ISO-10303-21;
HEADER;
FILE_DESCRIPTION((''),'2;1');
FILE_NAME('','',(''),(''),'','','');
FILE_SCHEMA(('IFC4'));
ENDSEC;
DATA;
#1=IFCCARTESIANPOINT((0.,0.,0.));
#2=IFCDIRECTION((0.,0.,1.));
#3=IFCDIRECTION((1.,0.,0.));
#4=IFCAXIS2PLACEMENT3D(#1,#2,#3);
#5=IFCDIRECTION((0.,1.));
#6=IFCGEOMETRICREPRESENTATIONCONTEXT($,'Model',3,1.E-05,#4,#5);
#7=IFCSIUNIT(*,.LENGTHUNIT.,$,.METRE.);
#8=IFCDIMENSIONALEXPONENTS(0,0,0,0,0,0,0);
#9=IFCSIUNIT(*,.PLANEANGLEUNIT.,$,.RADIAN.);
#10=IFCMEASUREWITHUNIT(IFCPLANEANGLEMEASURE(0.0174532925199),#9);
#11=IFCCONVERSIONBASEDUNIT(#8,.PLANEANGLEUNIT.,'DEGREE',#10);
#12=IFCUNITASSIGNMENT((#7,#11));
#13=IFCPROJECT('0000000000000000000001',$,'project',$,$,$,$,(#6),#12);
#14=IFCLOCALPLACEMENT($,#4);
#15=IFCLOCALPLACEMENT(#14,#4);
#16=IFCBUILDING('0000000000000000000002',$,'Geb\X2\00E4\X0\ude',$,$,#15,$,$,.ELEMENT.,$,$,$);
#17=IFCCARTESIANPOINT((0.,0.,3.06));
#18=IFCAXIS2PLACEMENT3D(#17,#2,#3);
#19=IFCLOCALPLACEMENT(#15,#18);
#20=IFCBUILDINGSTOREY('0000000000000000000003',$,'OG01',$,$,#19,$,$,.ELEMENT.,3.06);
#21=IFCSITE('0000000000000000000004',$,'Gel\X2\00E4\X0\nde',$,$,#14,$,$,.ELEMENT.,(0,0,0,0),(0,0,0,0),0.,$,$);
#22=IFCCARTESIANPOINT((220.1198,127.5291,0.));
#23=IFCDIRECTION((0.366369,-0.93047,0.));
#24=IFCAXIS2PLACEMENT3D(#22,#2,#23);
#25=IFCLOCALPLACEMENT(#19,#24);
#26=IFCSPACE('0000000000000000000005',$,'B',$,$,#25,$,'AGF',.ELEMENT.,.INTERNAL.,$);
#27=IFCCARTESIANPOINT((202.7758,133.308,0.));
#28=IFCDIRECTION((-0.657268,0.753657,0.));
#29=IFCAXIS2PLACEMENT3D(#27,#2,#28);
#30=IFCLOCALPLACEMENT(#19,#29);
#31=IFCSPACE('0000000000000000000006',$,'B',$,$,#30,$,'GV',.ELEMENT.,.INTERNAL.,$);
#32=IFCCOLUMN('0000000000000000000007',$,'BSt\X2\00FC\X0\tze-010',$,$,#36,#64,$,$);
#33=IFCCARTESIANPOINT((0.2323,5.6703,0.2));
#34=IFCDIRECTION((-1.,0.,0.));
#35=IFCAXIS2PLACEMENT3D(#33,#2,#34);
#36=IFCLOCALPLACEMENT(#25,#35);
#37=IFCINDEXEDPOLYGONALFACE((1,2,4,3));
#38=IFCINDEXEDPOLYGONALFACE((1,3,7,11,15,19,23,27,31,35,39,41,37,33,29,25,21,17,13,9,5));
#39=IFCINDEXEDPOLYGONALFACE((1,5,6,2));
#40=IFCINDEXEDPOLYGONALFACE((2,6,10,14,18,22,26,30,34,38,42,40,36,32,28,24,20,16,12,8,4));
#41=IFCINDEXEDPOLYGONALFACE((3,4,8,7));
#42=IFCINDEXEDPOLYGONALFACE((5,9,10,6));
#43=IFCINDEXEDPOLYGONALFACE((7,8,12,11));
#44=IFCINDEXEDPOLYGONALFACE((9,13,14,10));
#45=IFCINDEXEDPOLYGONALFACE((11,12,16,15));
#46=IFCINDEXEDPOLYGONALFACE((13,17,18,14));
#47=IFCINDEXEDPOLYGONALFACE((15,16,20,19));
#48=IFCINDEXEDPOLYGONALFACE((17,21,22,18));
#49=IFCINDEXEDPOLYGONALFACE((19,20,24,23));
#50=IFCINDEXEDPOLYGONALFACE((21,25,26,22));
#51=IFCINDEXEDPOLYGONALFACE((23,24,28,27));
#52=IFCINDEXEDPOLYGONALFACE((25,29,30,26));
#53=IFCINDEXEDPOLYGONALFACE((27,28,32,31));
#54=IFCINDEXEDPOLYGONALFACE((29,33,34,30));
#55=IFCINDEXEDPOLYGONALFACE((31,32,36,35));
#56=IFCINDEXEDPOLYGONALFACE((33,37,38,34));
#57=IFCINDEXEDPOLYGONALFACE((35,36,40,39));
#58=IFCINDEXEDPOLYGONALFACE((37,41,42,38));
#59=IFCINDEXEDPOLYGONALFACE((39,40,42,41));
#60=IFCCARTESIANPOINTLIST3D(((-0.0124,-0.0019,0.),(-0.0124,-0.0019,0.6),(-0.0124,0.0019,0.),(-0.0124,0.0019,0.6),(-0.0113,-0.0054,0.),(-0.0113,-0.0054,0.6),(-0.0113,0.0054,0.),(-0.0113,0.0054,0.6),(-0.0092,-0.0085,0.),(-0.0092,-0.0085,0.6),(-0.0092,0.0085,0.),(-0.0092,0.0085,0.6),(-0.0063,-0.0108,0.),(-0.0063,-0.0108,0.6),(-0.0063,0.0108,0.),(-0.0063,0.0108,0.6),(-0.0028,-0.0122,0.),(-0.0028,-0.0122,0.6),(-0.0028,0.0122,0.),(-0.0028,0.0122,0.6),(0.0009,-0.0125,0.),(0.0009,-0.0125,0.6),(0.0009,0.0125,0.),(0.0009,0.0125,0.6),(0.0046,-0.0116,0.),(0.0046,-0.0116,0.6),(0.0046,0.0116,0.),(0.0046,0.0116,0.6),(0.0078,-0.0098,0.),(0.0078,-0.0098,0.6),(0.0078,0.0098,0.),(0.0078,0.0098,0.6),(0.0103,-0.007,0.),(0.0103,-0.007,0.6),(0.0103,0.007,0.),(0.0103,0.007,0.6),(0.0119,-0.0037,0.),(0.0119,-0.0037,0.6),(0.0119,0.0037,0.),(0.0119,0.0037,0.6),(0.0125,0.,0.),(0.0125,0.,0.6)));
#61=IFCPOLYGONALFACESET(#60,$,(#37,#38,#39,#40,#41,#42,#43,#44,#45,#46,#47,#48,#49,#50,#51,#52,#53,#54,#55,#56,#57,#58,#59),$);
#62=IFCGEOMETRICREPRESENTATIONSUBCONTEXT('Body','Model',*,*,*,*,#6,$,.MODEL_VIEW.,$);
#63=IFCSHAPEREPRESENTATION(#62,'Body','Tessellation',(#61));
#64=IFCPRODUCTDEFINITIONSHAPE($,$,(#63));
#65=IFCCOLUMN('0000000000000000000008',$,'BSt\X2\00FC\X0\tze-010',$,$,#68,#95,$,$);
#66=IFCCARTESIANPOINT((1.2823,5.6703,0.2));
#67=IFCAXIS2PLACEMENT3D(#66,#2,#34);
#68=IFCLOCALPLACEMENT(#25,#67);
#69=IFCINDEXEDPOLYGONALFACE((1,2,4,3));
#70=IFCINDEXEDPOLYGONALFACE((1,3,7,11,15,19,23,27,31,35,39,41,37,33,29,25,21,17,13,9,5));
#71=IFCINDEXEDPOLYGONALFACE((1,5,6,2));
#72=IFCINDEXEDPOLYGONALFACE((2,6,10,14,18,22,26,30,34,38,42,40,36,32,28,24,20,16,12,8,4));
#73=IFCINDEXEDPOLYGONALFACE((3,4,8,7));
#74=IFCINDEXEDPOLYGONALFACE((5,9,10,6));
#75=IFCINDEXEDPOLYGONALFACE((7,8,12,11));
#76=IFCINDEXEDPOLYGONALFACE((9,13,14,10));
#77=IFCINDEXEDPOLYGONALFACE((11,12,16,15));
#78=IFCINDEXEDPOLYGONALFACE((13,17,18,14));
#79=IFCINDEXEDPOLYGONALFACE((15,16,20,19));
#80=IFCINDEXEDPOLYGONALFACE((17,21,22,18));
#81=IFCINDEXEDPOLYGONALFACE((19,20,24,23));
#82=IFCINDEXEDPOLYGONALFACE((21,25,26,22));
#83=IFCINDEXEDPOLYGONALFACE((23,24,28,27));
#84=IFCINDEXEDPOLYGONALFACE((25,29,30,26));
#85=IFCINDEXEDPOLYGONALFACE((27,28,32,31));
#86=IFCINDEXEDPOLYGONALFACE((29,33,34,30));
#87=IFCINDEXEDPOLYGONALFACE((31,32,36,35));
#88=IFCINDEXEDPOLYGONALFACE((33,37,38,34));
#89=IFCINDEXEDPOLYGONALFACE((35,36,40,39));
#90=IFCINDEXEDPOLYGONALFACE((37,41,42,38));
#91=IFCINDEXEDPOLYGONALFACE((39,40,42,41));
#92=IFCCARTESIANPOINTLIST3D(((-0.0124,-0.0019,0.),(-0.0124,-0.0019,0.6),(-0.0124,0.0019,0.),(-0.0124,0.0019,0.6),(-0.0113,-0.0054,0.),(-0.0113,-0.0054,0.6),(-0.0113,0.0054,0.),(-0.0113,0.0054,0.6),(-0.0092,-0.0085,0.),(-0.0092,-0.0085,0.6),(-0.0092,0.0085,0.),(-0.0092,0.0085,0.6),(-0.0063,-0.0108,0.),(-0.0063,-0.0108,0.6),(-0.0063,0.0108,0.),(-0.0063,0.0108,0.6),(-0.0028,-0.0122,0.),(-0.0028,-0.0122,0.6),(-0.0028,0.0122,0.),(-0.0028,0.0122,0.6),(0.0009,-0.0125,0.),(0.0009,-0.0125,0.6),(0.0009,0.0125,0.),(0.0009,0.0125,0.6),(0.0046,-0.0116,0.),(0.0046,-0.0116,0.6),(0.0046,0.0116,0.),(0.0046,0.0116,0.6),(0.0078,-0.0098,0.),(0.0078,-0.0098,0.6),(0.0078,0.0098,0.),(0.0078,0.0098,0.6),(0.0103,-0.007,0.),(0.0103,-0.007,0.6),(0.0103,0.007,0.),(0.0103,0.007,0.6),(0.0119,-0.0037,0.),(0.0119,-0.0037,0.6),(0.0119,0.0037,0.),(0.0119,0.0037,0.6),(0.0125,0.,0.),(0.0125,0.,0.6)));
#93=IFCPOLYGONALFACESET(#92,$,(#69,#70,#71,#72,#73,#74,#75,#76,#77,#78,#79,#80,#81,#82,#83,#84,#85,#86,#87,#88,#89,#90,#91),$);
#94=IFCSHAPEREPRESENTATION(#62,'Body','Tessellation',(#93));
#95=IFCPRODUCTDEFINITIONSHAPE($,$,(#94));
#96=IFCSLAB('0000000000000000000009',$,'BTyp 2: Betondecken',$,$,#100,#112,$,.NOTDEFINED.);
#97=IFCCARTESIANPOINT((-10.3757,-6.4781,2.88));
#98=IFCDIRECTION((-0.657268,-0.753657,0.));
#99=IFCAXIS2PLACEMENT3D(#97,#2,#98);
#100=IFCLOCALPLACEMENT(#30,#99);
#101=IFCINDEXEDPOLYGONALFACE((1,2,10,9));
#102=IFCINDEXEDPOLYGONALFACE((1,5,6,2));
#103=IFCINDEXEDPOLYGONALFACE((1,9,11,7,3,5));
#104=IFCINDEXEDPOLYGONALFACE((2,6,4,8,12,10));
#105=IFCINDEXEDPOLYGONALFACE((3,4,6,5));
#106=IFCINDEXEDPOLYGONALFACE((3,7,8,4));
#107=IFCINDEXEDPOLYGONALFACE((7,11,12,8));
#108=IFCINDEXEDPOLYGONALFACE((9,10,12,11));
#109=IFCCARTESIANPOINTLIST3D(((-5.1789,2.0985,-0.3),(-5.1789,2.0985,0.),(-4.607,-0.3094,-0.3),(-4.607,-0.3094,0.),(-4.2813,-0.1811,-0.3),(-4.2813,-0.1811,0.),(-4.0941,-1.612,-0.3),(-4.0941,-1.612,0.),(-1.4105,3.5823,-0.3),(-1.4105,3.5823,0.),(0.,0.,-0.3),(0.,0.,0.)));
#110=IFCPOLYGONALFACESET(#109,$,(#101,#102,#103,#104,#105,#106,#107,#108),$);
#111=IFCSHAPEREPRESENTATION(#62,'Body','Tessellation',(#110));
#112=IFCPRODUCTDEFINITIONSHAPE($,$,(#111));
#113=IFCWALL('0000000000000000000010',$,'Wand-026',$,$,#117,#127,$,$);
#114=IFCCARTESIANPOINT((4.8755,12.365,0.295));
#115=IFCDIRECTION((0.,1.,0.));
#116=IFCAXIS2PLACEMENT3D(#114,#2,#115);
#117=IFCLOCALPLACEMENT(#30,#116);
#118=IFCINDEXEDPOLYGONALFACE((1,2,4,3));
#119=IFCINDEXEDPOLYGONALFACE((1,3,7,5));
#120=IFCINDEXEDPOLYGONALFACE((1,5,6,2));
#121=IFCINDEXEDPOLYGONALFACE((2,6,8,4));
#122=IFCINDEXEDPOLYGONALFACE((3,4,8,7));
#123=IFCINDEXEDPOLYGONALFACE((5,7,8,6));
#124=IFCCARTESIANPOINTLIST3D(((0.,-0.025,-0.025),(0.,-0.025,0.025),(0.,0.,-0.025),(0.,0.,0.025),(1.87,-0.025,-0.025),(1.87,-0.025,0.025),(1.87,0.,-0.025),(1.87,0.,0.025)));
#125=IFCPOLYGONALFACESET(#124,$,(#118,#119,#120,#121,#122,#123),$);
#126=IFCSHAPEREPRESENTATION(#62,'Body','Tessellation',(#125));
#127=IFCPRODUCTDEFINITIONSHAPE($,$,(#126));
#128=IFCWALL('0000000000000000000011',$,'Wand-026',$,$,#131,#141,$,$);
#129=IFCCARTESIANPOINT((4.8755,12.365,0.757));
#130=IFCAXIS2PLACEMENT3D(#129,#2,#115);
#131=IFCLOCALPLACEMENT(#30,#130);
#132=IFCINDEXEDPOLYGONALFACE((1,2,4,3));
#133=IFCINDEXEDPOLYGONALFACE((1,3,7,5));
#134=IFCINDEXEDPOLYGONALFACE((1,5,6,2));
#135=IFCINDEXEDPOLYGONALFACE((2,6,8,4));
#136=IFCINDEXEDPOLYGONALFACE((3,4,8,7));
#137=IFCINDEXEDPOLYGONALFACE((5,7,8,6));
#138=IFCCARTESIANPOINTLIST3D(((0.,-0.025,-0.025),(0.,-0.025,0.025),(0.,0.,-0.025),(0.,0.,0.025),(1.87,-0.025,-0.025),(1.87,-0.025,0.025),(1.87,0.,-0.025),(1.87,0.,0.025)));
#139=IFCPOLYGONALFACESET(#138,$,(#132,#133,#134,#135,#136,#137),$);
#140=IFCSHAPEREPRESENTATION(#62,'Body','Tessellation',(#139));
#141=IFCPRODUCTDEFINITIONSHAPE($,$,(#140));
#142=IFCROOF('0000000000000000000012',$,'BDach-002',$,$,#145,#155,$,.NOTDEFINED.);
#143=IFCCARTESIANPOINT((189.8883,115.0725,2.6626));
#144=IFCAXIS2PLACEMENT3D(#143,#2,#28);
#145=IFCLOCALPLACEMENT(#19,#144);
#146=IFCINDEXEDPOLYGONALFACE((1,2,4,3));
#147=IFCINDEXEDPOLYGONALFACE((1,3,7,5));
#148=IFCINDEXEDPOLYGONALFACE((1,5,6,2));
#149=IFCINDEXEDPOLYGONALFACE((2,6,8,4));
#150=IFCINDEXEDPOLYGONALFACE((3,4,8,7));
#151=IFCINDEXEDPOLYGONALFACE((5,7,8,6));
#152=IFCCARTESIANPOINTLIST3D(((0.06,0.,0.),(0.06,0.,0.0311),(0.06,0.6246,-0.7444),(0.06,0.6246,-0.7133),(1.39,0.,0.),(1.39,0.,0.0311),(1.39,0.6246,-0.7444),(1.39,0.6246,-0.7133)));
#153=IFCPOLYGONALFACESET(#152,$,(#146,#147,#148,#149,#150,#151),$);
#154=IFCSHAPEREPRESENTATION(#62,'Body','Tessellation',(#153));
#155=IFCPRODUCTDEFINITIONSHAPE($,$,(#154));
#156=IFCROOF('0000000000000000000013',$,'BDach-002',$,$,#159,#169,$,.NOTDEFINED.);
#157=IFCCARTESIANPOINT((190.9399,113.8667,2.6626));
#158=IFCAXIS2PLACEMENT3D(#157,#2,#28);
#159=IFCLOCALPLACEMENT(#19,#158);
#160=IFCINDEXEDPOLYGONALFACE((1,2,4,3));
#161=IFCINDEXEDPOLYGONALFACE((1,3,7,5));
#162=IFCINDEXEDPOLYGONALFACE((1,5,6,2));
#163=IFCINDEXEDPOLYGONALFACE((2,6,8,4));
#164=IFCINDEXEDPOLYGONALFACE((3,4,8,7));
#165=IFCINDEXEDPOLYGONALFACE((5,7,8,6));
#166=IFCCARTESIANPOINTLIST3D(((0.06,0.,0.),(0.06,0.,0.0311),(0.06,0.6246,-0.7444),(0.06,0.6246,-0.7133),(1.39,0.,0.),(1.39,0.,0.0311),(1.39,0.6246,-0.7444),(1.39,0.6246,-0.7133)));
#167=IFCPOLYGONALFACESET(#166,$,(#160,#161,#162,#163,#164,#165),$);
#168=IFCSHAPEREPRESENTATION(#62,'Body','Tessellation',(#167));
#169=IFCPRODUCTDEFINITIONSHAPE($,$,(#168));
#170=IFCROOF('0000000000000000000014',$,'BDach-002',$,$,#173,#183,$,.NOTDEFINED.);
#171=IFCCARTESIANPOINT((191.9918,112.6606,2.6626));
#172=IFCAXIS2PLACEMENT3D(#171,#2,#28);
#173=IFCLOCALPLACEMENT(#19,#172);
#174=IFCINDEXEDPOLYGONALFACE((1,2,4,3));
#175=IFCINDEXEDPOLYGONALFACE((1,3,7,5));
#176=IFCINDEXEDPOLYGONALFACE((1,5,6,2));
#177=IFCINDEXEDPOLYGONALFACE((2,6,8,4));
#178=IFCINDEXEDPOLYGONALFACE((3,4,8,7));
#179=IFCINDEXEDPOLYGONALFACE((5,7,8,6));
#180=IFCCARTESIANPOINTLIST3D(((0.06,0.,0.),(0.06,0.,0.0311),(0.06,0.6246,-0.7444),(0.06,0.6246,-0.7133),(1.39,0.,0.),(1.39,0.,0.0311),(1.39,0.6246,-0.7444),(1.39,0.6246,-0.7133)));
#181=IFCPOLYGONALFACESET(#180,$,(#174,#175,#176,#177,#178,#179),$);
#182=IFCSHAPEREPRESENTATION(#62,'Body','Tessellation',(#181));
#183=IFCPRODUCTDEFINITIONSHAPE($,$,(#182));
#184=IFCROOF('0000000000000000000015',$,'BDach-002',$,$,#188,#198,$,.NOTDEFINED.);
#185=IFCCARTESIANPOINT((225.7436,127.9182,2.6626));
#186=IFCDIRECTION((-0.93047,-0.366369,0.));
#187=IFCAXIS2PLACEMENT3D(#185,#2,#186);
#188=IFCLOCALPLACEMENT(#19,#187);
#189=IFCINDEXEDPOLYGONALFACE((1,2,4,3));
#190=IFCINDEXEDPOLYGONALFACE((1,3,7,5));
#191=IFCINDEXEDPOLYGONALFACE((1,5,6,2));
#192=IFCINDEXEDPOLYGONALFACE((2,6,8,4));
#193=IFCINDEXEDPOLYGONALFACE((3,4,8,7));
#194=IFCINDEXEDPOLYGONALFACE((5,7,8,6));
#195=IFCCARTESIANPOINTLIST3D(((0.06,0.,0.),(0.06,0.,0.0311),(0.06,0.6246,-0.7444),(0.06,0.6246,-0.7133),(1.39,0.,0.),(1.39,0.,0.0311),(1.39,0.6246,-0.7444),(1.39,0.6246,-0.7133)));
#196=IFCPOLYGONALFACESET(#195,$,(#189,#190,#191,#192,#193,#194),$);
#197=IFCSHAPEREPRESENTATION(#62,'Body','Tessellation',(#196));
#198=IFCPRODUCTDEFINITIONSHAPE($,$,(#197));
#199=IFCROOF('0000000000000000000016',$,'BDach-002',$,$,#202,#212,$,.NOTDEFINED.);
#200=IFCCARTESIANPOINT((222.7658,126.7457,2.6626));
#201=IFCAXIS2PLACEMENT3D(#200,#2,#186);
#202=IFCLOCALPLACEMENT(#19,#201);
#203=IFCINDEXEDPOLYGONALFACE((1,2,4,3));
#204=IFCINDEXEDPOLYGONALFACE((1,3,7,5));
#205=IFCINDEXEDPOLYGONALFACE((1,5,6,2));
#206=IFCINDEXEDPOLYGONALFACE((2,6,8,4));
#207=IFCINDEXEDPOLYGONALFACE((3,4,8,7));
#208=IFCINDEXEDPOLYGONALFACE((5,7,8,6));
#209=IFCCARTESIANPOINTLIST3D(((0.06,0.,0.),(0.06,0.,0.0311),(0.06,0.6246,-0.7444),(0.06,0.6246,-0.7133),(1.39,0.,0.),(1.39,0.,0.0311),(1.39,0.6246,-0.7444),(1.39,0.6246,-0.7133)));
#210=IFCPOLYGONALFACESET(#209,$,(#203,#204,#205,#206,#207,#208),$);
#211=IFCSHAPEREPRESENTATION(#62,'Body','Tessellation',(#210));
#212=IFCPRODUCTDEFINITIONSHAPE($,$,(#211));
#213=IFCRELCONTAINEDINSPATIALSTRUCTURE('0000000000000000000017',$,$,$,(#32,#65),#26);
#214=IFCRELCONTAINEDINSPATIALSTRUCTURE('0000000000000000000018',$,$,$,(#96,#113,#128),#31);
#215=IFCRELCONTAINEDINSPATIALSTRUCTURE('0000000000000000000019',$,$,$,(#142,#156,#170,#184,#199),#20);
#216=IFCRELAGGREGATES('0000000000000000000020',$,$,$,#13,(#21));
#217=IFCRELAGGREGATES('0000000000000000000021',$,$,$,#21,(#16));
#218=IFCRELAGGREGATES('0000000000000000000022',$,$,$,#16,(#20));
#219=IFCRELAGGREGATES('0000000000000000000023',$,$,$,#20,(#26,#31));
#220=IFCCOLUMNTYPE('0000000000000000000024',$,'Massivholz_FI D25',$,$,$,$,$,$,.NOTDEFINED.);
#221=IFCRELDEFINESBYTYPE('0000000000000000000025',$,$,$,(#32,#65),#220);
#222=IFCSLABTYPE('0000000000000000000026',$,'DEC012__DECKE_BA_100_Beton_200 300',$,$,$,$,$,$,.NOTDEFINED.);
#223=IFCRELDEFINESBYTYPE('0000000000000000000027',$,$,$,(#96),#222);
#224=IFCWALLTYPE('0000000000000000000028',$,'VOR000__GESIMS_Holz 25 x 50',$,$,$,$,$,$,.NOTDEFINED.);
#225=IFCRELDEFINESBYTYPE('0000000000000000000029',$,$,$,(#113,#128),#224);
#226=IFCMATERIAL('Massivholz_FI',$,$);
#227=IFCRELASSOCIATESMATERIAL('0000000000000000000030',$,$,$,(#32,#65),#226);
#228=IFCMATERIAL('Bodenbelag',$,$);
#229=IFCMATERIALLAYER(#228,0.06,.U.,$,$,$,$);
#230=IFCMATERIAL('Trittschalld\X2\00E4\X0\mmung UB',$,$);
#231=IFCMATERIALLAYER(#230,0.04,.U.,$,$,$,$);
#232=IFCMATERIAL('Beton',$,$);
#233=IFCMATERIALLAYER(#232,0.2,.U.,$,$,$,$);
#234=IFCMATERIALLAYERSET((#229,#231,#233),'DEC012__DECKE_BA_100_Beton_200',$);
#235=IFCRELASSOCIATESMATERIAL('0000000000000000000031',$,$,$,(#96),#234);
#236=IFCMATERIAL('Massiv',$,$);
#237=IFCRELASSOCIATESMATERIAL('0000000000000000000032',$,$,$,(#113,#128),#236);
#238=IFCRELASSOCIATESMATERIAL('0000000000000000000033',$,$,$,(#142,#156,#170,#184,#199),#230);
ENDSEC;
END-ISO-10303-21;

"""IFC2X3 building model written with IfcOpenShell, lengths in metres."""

from ifc_helpers import new_model, entity, si_unit, converted_unit, direction, frame, origin_with_axes, origin_2d_with_axis, place, context, subcontext, project, spatial, polyline, circle, outline, extrude, material, layer, layer_set, layer_usage, type_object, element, save


model = new_model("IFC2X3")

# Units and contexts
model_context = context("Model", 3, precision=1e-05, world=origin_with_axes(), true_north=direction((0.0, 1.0)))
body_context = subcontext(model_context, "Body", "Model", "MODEL_VIEW")
ifc_project = project(units=[si_unit("LENGTHUNIT", "METRE"), converted_unit("PLANEANGLEUNIT", "DEGREE", entity("IfcPlaneAngleMeasure", 0.0174532925199), si_unit("PLANEANGLEUNIT", "RADIAN"), dimensions=[0, 0, 0, 0, 0, 0, 0])], contexts=[model_context])

# Site, building, storey
site_placement = place(None, origin_with_axes())
site = spatial("IfcSite", under=ifc_project, at=site_placement, Name="Gelände", CompositionType="ELEMENT", RefLatitude=(0, 0, 0, 0), RefLongitude=(0, 0, 0, 0), RefElevation=0.0)
building_placement = place(site_placement, origin_with_axes())
building = spatial("IfcBuilding", under=site, at=building_placement, Name="Gebäude", CompositionType="ELEMENT")
storey_placement = place(building_placement, frame((0.0, 0.0, 3.06), z_axis=(0.0, 0.0, 1.0), x_axis=(1.0, 0.0, 0.0)))
storey = spatial("IfcBuildingStorey", under=building, at=storey_placement, Name="OG01", CompositionType="ELEMENT", Elevation=3.06)

# Shared definitions
ifc_material_1 = material(Name="Massivholz_FI")
column_type = type_object("IfcColumnType", Name="Massivholz_FI D25", PredefinedType="NOTDEFINED")

# Shared definitions
space_1_placement = place(storey_placement, frame((220.1198, 127.5291, 0.0), z_axis=(0.0, 0.0, 1.0), x_axis=(0.366369, -0.93047, 0.0)))
space_1 = spatial("IfcSpace", under=storey, at=space_1_placement, Name="B", LongName="AGF", CompositionType="ELEMENT", InteriorOrExteriorSpace="INTERNAL")

# Columns
for number, where, z_axis, x_axis, name in (
    (1, (0.2323, 5.6703, 0.2), (0.0, 0.0, 1.0), (-1.0, 0.0, 0.0), "BStütze-010"),
    (2, (1.2823, 5.6703, 0.2), (0.0, 0.0, 1.0), (-1.0, 0.0, 0.0), "BStütze-010"),
):
    element("IfcColumn", number, at=place(space_1_placement, frame(where, z_axis=z_axis, x_axis=x_axis)), inside=space_1, type_object=column_type, material=ifc_material_1, Name=name, context=body_context, shape_type="SweptSolid", body=[
        extrude(circle(Radius=0.0125, at=origin_2d_with_axis()), origin_with_axes(), (0.0, 0.0, 1.0), 0.6),
    ])

# Shared definitions
space_2_placement = place(storey_placement, frame((202.7758, 133.308, 0.0), z_axis=(0.0, 0.0, 1.0), x_axis=(-0.657268, 0.753657, 0.0)))
space_2 = spatial("IfcSpace", under=storey, at=space_2_placement, Name="B", LongName="GV", CompositionType="ELEMENT", InteriorOrExteriorSpace="INTERNAL")

# Slab
ifc_material_2 = material(Name="Bodenbelag")
ifc_layer_1 = layer(ifc_material_2, 0.06, ventilated="UNKNOWN")
ifc_material_3 = material(Name="Trittschalldämmung UB")
ifc_layer_2 = layer(ifc_material_3, 0.04, ventilated="UNKNOWN")
ifc_material_4 = material(Name="Beton")
ifc_layer_3 = layer(ifc_material_4, 0.2, ventilated="UNKNOWN")
ifc_layer_set_1 = layer_set([ifc_layer_1, ifc_layer_2, ifc_layer_3], Name="DEC012__DECKE_BA_100_Beton_200")
ifc_layer_usage_1 = layer_usage(ifc_layer_set_1, "AXIS3", "NEGATIVE", 0.3)
slab_type_1 = type_object("IfcSlabType", Name="DEC012__DECKE_BA_100_Beton_200 300", PredefinedType="NOTDEFINED")
slab_1_placement = place(space_2_placement, frame((-10.3757, -6.4781, 2.88), z_axis=(0.0, 0.0, 1.0), x_axis=(-0.657268, -0.753657, 0.0)))
element("IfcSlab", 3, at=slab_1_placement, inside=space_2, type_object=slab_type_1, material=ifc_layer_usage_1, Name="BTyp 2: Betondecken", PredefinedType="NOTDEFINED", context=body_context, shape_type="SweptSolid", body=[
    extrude(outline(polyline([(0.0, 0.0), (-1.4105, 3.5823), (-5.1789, 2.0985), (-4.2813, -0.1811), (-4.607, -0.3094), (-4.0941, -1.612), (0.0, 0.0)])), frame((0.0, 0.0, -0.3), z_axis=(0.0, 0.0, 1.0), x_axis=(1.0, 0.0, 0.0)), (0.0, 0.0, 1.0), 0.3),
])

# Walls
ifc_material_5 = material(Name="Massiv")
wall_type = type_object("IfcWallType", Name="VOR000__GESIMS_Holz 25 x 50", PredefinedType="NOTDEFINED")
for number, where, z_axis, x_axis, name in (
    (4, (4.8755, 12.365, 0.295), (0.0, 0.0, 1.0), (0.0, 1.0, 0.0), "Wand-026"),
    (5, (4.8755, 12.365, 0.757), (0.0, 0.0, 1.0), (0.0, 1.0, 0.0), "Wand-026"),
):
    element("IfcWall", number, at=place(space_2_placement, frame(where, z_axis=z_axis, x_axis=x_axis)), inside=space_2, type_object=wall_type, material=ifc_material_5, Name=name, context=body_context, shape_type="SweptSolid", body=[
        extrude(outline(polyline([(0.0, -0.025), (0.0, 0.025), (-0.025, 0.025), (-0.025, -0.025), (0.0, -0.025)])), frame((0.0, 0.0, 0.0), z_axis=(1.0, 0.0, 0.0), x_axis=(0.0, 1.0, 0.0)), (0.0, 0.0, 1.0), 1.87),
    ])

# Roofs
roof_1_placement = place(storey_placement, frame((189.8883, 115.0725, 2.6626), z_axis=(0.0, 0.0, 1.0), x_axis=(-0.657268, 0.753657, 0.0)))
element("IfcRoof", 6, at=roof_1_placement, inside=storey, material=ifc_material_3, Name="BDach-002", ShapeType="NOTDEFINED", context=body_context, shape_type="SweptSolid", body=[
    extrude(outline(polyline([(1.39, 0.0), (1.39, 0.9717), (0.06, 0.9717), (0.06, 0.0), (1.39, 0.0)])), frame((0.0, 0.0, 0.0), z_axis=(0.0, 0.766044, 0.642788), x_axis=(1.0, 0.0, 0.0)), (0.0, -0.766044, 0.642788), 0.0311),
])
roof_2_placement = place(storey_placement, frame((190.9399, 113.8667, 2.6626), z_axis=(0.0, 0.0, 1.0), x_axis=(-0.657268, 0.753657, 0.0)))
element("IfcRoof", 7, at=roof_2_placement, inside=storey, material=ifc_material_3, Name="BDach-002", ShapeType="NOTDEFINED", context=body_context, shape_type="SweptSolid", body=[
    extrude(outline(polyline([(1.39, 0.0), (1.39, 0.9717), (0.06, 0.9717), (0.06, 0.0), (1.39, 0.0)])), frame((0.0, 0.0, 0.0), z_axis=(0.0, 0.766044, 0.642788), x_axis=(1.0, 0.0, 0.0)), (0.0, -0.766044, 0.642788), 0.0311),
])
for number, where, z_axis, x_axis, name in (
    (8, (191.9918, 112.6606, 2.6626), (0.0, 0.0, 1.0), (-0.657268, 0.753657, 0.0), "BDach-002"),
    (9, (225.7436, 127.9182, 2.6626), (0.0, 0.0, 1.0), (-0.93047, -0.366369, 0.0), "BDach-002"),
):
    element("IfcRoof", number, at=place(storey_placement, frame(where, z_axis=z_axis, x_axis=x_axis)), inside=storey, material=ifc_material_3, Name=name, ShapeType="NOTDEFINED", context=body_context, shape_type="SweptSolid", body=[
        extrude(outline(polyline([(1.39, 0.0), (1.39, 0.9717), (0.06, 0.9717), (0.06, 0.0), (1.39, 0.0)])), frame((0.0, 0.0, 0.0), z_axis=(0.0, 0.766044, 0.642788), x_axis=(1.0, 0.0, 0.0)), (0.0, -0.766044, 0.642788), 0.0311),
    ])
roof_3_placement = place(storey_placement, frame((222.7658, 126.7457, 2.6626), z_axis=(0.0, 0.0, 1.0), x_axis=(-0.93047, -0.366369, 0.0)))
element("IfcRoof", 10, at=roof_3_placement, inside=storey, material=ifc_material_3, Name="BDach-002", ShapeType="NOTDEFINED", context=body_context, shape_type="SweptSolid", body=[
    extrude(outline(polyline([(1.39, 0.0), (1.39, 0.9717), (0.06, 0.9717), (0.06, 0.0), (1.39, 0.0)])), frame((0.0, 0.0, 0.0), z_axis=(0.0, 0.766044, 0.642788), x_axis=(1.0, 0.0, 0.0)), (0.0, -0.766044, 0.642788), 0.0311),
])

save(model, "model.ifc")
